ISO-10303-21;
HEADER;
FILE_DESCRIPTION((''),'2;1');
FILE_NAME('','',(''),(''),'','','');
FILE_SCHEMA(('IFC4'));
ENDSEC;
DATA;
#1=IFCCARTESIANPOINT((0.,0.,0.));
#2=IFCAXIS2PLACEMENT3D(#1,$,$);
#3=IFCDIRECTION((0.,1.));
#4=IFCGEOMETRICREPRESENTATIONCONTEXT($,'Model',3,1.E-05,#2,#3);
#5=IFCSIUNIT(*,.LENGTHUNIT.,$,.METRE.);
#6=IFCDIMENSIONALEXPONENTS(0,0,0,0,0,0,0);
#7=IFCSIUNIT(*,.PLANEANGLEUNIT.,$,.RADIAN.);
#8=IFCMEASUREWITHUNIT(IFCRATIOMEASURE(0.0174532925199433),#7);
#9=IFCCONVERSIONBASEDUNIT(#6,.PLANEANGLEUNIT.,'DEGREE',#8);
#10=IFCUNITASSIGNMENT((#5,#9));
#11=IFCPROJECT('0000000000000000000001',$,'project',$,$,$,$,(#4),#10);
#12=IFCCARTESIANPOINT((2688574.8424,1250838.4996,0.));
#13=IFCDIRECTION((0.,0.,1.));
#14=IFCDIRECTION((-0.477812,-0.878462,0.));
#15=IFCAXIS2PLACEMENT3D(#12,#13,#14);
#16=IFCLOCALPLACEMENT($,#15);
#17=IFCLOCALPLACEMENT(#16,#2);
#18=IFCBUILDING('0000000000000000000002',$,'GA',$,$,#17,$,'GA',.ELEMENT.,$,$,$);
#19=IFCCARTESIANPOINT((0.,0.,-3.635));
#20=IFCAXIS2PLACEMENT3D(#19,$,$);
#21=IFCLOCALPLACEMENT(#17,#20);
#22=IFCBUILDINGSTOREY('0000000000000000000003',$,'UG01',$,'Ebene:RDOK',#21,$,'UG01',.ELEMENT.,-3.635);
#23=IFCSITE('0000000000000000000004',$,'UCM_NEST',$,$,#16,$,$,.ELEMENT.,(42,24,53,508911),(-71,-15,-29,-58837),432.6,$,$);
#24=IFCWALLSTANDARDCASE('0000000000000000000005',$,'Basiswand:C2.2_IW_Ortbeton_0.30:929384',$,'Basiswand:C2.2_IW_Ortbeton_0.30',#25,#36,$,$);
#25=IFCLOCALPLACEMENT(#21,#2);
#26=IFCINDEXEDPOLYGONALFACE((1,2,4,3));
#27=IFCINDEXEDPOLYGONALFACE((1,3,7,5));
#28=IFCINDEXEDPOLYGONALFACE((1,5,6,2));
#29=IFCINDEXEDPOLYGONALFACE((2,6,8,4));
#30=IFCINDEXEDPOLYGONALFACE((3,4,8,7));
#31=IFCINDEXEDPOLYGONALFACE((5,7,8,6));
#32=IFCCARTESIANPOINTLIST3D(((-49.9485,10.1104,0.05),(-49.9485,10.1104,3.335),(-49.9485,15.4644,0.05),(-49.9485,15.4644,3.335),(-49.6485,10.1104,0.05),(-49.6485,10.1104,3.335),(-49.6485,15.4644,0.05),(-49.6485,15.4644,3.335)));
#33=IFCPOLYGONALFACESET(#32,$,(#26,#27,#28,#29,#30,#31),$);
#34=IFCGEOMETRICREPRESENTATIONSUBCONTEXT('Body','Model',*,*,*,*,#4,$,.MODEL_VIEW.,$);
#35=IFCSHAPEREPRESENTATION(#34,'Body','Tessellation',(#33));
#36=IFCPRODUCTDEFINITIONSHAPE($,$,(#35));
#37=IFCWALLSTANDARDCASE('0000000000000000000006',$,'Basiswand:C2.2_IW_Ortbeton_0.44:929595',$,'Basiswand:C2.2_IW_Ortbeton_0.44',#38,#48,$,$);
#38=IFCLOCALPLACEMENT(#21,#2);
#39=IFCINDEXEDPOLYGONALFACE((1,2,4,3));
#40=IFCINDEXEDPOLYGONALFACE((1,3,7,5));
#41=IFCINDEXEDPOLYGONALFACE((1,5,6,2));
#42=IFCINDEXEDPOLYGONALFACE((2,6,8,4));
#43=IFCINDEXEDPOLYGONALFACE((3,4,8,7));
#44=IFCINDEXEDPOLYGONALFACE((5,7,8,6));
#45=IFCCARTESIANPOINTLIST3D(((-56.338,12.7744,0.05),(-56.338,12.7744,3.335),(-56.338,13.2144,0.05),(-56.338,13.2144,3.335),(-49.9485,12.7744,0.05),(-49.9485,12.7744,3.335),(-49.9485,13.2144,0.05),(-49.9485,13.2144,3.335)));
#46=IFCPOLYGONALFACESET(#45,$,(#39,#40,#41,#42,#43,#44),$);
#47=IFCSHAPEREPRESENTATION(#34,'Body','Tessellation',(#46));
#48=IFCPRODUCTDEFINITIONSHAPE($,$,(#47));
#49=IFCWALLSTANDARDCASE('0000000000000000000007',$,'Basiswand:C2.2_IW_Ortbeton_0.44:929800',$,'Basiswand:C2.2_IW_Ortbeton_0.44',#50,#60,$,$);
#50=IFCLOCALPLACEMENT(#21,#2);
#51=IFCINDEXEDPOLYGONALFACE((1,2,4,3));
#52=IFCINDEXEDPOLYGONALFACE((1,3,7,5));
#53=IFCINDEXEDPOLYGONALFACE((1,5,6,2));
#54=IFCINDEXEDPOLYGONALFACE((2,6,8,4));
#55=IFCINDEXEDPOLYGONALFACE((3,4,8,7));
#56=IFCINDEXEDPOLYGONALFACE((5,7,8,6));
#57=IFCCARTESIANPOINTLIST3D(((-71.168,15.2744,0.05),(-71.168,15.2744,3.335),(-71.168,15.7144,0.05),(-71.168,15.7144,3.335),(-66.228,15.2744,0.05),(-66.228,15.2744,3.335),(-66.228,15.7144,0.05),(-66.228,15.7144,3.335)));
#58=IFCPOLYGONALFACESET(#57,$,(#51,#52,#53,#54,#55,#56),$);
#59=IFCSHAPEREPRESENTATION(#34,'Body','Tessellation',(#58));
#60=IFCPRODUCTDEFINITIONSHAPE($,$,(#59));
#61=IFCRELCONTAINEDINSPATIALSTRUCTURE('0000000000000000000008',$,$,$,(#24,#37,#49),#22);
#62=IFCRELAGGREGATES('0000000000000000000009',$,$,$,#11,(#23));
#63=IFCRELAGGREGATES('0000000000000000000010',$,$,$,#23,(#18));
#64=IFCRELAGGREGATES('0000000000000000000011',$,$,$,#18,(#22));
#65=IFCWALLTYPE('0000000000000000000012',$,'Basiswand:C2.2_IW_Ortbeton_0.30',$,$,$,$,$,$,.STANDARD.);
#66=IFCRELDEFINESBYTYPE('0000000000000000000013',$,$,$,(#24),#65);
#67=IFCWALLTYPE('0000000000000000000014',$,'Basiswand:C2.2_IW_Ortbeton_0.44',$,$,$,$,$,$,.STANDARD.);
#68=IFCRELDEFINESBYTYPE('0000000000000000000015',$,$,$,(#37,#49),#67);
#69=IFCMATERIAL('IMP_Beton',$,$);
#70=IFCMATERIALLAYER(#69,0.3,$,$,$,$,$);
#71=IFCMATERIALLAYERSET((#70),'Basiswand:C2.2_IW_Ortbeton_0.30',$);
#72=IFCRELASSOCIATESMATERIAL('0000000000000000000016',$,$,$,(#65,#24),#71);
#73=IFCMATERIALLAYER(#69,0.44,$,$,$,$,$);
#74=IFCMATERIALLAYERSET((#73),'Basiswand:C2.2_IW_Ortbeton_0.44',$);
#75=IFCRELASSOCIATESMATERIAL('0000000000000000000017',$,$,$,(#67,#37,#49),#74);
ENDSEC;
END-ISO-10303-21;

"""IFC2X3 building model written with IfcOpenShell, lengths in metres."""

from ifc_helpers import new_model, entity, si_unit, converted_unit, direction, frame, frame_2d, origin, place, context, subcontext, project, spatial, polyline, rectangle, extrude, clip, bounded_halfspace, material, layer, layer_set, layer_usage, type_object, element, save


model = new_model("IFC2X3")

# Units and contexts
model_context = context("Model", 3, precision=1e-05, world=origin(), true_north=direction((0.0, 1.0)))
body_context = subcontext(model_context, "Body", "Model", "MODEL_VIEW")
ifc_project = project(units=[si_unit("LENGTHUNIT", "METRE"), converted_unit("PLANEANGLEUNIT", "DEGREE", entity("IfcRatioMeasure", 0.0174532925199433), si_unit("PLANEANGLEUNIT", "RADIAN"), dimensions=[0, 0, 0, 0, 0, 0, 0])], contexts=[model_context])

# Site, building, storey
site_placement = place(None, frame((2688574.8424, 1250838.4996, 0.0), z_axis=(0.0, 0.0, 1.0), x_axis=(-0.477812, -0.878462, 0.0)))
site = spatial("IfcSite", under=ifc_project, at=site_placement, Name="UCM_NEST", CompositionType="ELEMENT", RefLatitude=(42, 24, 53, 508911), RefLongitude=(-71, -15, -29, -58837), RefElevation=432.6)
building_placement = place(site_placement, origin())
building = spatial("IfcBuilding", under=site, at=building_placement, Name="GA", LongName="GA", CompositionType="ELEMENT")
storey_placement = place(building_placement, frame((0.0, 0.0, -3.635)))
storey = spatial("IfcBuildingStorey", under=building, at=storey_placement, Name="UG01", ObjectType="Ebene:RDOK", LongName="UG01", CompositionType="ELEMENT", Elevation=-3.635)

# Walls
ifc_material_1 = material(Name="IMP_Beton")
ifc_layer_1 = layer(ifc_material_1, 0.3)
ifc_layer_set_1 = layer_set([ifc_layer_1], Name="Basiswand:C2.2_IW_Ortbeton_0.30")
ifc_layer_usage_1 = layer_usage(ifc_layer_set_1, "AXIS2", "NEGATIVE", 0.15)
wall_type_1 = type_object("IfcWallType", Name="Basiswand:C2.2_IW_Ortbeton_0.30", PredefinedType="STANDARD", material=ifc_layer_set_1)
wall_1_placement = place(storey_placement, frame((-49.7985, 15.4644, 0.05), z_axis=(0.0, 0.0, 1.0), x_axis=(0.0, -1.0, 0.0)))
element("IfcWallStandardCase", 1, at=wall_1_placement, inside=storey, type_object=wall_type_1, material=ifc_layer_usage_1, Name="Basiswand:C2.2_IW_Ortbeton_0.30:929384", ObjectType="Basiswand:C2.2_IW_Ortbeton_0.30", context=body_context, shape_type="Clipping", body=[
    clip(extrude(rectangle(XDim=5.354, YDim=0.3, at=frame_2d((2.677, 0.0), x_axis=(-1.0, 0.0))), origin(), (0.0, 0.0, 1.0), 3.285), bounded_halfspace(frame((5.354, -0.15, 0.0), z_axis=(0.0, 0.0, 1.0), x_axis=(-1.0, 0.0, 0.0)), True, frame((5.354, -0.15, 0.0), z_axis=(0.0, 0.0, 1.0), x_axis=(-1.0, 0.0, 0.0)), polyline([(0.0, 0.0), (0.0, -0.3), (5.354, -0.3), (5.354, 0.0), (3.104, 0.0), (2.664, 0.0), (0.0, 0.0)]))),
])
ifc_layer_2 = layer(ifc_material_1, 0.44)
ifc_layer_set_2 = layer_set([ifc_layer_2], Name="Basiswand:C2.2_IW_Ortbeton_0.44")
ifc_layer_usage_2 = layer_usage(ifc_layer_set_2, "AXIS2", "NEGATIVE", 0.22)
wall_type_2 = type_object("IfcWallType", Name="Basiswand:C2.2_IW_Ortbeton_0.44", PredefinedType="STANDARD", material=ifc_layer_set_2)
wall_2_placement = place(storey_placement, frame((-49.9485, 12.9944, 0.05), z_axis=(0.0, 0.0, 1.0), x_axis=(-1.0, 0.0, 0.0)))
element("IfcWallStandardCase", 2, at=wall_2_placement, inside=storey, type_object=wall_type_2, material=ifc_layer_usage_2, Name="Basiswand:C2.2_IW_Ortbeton_0.44:929595", ObjectType="Basiswand:C2.2_IW_Ortbeton_0.44", context=body_context, shape_type="Clipping", body=[
    clip(extrude(rectangle(XDim=6.3895, YDim=0.44, at=frame_2d((3.1947, 0.0), x_axis=(-1.0, 0.0))), origin(), (0.0, 0.0, 1.0), 3.285), bounded_halfspace(frame((6.3895, -0.22, 0.0), z_axis=(0.0, 0.0, 1.0), x_axis=(0.0, -1.0, 0.0)), True, frame((6.3895, -0.22, 0.0), z_axis=(0.0, 0.0, 1.0), x_axis=(0.0, -1.0, 0.0)), polyline([(0.0, 0.0), (-0.44, 0.0), (-0.44, -6.3895), (0.0, -6.3895), (0.0, 0.0)]))),
])
ifc_layer_usage_3 = layer_usage(ifc_layer_set_2, "AXIS2", "NEGATIVE", 0.22)
wall_3_placement = place(storey_placement, frame((-66.228, 15.4944, 0.05), z_axis=(0.0, 0.0, 1.0), x_axis=(-1.0, 0.0, 0.0)))
element("IfcWallStandardCase", 3, at=wall_3_placement, inside=storey, type_object=wall_type_2, material=ifc_layer_usage_3, Name="Basiswand:C2.2_IW_Ortbeton_0.44:929800", ObjectType="Basiswand:C2.2_IW_Ortbeton_0.44", context=body_context, shape_type="Clipping", body=[
    clip(extrude(rectangle(XDim=4.94, YDim=0.44, at=frame_2d((2.47, 0.0), x_axis=(-1.0, 0.0))), origin(), (0.0, 0.0, 1.0), 3.285), bounded_halfspace(frame((4.94, -0.22, 0.0), z_axis=(0.0, 0.0, 1.0), x_axis=(0.0, -1.0, 0.0)), True, frame((4.94, -0.22, 0.0), z_axis=(0.0, 0.0, 1.0), x_axis=(0.0, -1.0, 0.0)), polyline([(0.0, 0.0), (-0.44, 0.0), (-0.44, -4.94), (-0.25, -4.94), (0.0, -4.94), (0.0, 0.0)]))),
])

save(model, "model.ifc")
